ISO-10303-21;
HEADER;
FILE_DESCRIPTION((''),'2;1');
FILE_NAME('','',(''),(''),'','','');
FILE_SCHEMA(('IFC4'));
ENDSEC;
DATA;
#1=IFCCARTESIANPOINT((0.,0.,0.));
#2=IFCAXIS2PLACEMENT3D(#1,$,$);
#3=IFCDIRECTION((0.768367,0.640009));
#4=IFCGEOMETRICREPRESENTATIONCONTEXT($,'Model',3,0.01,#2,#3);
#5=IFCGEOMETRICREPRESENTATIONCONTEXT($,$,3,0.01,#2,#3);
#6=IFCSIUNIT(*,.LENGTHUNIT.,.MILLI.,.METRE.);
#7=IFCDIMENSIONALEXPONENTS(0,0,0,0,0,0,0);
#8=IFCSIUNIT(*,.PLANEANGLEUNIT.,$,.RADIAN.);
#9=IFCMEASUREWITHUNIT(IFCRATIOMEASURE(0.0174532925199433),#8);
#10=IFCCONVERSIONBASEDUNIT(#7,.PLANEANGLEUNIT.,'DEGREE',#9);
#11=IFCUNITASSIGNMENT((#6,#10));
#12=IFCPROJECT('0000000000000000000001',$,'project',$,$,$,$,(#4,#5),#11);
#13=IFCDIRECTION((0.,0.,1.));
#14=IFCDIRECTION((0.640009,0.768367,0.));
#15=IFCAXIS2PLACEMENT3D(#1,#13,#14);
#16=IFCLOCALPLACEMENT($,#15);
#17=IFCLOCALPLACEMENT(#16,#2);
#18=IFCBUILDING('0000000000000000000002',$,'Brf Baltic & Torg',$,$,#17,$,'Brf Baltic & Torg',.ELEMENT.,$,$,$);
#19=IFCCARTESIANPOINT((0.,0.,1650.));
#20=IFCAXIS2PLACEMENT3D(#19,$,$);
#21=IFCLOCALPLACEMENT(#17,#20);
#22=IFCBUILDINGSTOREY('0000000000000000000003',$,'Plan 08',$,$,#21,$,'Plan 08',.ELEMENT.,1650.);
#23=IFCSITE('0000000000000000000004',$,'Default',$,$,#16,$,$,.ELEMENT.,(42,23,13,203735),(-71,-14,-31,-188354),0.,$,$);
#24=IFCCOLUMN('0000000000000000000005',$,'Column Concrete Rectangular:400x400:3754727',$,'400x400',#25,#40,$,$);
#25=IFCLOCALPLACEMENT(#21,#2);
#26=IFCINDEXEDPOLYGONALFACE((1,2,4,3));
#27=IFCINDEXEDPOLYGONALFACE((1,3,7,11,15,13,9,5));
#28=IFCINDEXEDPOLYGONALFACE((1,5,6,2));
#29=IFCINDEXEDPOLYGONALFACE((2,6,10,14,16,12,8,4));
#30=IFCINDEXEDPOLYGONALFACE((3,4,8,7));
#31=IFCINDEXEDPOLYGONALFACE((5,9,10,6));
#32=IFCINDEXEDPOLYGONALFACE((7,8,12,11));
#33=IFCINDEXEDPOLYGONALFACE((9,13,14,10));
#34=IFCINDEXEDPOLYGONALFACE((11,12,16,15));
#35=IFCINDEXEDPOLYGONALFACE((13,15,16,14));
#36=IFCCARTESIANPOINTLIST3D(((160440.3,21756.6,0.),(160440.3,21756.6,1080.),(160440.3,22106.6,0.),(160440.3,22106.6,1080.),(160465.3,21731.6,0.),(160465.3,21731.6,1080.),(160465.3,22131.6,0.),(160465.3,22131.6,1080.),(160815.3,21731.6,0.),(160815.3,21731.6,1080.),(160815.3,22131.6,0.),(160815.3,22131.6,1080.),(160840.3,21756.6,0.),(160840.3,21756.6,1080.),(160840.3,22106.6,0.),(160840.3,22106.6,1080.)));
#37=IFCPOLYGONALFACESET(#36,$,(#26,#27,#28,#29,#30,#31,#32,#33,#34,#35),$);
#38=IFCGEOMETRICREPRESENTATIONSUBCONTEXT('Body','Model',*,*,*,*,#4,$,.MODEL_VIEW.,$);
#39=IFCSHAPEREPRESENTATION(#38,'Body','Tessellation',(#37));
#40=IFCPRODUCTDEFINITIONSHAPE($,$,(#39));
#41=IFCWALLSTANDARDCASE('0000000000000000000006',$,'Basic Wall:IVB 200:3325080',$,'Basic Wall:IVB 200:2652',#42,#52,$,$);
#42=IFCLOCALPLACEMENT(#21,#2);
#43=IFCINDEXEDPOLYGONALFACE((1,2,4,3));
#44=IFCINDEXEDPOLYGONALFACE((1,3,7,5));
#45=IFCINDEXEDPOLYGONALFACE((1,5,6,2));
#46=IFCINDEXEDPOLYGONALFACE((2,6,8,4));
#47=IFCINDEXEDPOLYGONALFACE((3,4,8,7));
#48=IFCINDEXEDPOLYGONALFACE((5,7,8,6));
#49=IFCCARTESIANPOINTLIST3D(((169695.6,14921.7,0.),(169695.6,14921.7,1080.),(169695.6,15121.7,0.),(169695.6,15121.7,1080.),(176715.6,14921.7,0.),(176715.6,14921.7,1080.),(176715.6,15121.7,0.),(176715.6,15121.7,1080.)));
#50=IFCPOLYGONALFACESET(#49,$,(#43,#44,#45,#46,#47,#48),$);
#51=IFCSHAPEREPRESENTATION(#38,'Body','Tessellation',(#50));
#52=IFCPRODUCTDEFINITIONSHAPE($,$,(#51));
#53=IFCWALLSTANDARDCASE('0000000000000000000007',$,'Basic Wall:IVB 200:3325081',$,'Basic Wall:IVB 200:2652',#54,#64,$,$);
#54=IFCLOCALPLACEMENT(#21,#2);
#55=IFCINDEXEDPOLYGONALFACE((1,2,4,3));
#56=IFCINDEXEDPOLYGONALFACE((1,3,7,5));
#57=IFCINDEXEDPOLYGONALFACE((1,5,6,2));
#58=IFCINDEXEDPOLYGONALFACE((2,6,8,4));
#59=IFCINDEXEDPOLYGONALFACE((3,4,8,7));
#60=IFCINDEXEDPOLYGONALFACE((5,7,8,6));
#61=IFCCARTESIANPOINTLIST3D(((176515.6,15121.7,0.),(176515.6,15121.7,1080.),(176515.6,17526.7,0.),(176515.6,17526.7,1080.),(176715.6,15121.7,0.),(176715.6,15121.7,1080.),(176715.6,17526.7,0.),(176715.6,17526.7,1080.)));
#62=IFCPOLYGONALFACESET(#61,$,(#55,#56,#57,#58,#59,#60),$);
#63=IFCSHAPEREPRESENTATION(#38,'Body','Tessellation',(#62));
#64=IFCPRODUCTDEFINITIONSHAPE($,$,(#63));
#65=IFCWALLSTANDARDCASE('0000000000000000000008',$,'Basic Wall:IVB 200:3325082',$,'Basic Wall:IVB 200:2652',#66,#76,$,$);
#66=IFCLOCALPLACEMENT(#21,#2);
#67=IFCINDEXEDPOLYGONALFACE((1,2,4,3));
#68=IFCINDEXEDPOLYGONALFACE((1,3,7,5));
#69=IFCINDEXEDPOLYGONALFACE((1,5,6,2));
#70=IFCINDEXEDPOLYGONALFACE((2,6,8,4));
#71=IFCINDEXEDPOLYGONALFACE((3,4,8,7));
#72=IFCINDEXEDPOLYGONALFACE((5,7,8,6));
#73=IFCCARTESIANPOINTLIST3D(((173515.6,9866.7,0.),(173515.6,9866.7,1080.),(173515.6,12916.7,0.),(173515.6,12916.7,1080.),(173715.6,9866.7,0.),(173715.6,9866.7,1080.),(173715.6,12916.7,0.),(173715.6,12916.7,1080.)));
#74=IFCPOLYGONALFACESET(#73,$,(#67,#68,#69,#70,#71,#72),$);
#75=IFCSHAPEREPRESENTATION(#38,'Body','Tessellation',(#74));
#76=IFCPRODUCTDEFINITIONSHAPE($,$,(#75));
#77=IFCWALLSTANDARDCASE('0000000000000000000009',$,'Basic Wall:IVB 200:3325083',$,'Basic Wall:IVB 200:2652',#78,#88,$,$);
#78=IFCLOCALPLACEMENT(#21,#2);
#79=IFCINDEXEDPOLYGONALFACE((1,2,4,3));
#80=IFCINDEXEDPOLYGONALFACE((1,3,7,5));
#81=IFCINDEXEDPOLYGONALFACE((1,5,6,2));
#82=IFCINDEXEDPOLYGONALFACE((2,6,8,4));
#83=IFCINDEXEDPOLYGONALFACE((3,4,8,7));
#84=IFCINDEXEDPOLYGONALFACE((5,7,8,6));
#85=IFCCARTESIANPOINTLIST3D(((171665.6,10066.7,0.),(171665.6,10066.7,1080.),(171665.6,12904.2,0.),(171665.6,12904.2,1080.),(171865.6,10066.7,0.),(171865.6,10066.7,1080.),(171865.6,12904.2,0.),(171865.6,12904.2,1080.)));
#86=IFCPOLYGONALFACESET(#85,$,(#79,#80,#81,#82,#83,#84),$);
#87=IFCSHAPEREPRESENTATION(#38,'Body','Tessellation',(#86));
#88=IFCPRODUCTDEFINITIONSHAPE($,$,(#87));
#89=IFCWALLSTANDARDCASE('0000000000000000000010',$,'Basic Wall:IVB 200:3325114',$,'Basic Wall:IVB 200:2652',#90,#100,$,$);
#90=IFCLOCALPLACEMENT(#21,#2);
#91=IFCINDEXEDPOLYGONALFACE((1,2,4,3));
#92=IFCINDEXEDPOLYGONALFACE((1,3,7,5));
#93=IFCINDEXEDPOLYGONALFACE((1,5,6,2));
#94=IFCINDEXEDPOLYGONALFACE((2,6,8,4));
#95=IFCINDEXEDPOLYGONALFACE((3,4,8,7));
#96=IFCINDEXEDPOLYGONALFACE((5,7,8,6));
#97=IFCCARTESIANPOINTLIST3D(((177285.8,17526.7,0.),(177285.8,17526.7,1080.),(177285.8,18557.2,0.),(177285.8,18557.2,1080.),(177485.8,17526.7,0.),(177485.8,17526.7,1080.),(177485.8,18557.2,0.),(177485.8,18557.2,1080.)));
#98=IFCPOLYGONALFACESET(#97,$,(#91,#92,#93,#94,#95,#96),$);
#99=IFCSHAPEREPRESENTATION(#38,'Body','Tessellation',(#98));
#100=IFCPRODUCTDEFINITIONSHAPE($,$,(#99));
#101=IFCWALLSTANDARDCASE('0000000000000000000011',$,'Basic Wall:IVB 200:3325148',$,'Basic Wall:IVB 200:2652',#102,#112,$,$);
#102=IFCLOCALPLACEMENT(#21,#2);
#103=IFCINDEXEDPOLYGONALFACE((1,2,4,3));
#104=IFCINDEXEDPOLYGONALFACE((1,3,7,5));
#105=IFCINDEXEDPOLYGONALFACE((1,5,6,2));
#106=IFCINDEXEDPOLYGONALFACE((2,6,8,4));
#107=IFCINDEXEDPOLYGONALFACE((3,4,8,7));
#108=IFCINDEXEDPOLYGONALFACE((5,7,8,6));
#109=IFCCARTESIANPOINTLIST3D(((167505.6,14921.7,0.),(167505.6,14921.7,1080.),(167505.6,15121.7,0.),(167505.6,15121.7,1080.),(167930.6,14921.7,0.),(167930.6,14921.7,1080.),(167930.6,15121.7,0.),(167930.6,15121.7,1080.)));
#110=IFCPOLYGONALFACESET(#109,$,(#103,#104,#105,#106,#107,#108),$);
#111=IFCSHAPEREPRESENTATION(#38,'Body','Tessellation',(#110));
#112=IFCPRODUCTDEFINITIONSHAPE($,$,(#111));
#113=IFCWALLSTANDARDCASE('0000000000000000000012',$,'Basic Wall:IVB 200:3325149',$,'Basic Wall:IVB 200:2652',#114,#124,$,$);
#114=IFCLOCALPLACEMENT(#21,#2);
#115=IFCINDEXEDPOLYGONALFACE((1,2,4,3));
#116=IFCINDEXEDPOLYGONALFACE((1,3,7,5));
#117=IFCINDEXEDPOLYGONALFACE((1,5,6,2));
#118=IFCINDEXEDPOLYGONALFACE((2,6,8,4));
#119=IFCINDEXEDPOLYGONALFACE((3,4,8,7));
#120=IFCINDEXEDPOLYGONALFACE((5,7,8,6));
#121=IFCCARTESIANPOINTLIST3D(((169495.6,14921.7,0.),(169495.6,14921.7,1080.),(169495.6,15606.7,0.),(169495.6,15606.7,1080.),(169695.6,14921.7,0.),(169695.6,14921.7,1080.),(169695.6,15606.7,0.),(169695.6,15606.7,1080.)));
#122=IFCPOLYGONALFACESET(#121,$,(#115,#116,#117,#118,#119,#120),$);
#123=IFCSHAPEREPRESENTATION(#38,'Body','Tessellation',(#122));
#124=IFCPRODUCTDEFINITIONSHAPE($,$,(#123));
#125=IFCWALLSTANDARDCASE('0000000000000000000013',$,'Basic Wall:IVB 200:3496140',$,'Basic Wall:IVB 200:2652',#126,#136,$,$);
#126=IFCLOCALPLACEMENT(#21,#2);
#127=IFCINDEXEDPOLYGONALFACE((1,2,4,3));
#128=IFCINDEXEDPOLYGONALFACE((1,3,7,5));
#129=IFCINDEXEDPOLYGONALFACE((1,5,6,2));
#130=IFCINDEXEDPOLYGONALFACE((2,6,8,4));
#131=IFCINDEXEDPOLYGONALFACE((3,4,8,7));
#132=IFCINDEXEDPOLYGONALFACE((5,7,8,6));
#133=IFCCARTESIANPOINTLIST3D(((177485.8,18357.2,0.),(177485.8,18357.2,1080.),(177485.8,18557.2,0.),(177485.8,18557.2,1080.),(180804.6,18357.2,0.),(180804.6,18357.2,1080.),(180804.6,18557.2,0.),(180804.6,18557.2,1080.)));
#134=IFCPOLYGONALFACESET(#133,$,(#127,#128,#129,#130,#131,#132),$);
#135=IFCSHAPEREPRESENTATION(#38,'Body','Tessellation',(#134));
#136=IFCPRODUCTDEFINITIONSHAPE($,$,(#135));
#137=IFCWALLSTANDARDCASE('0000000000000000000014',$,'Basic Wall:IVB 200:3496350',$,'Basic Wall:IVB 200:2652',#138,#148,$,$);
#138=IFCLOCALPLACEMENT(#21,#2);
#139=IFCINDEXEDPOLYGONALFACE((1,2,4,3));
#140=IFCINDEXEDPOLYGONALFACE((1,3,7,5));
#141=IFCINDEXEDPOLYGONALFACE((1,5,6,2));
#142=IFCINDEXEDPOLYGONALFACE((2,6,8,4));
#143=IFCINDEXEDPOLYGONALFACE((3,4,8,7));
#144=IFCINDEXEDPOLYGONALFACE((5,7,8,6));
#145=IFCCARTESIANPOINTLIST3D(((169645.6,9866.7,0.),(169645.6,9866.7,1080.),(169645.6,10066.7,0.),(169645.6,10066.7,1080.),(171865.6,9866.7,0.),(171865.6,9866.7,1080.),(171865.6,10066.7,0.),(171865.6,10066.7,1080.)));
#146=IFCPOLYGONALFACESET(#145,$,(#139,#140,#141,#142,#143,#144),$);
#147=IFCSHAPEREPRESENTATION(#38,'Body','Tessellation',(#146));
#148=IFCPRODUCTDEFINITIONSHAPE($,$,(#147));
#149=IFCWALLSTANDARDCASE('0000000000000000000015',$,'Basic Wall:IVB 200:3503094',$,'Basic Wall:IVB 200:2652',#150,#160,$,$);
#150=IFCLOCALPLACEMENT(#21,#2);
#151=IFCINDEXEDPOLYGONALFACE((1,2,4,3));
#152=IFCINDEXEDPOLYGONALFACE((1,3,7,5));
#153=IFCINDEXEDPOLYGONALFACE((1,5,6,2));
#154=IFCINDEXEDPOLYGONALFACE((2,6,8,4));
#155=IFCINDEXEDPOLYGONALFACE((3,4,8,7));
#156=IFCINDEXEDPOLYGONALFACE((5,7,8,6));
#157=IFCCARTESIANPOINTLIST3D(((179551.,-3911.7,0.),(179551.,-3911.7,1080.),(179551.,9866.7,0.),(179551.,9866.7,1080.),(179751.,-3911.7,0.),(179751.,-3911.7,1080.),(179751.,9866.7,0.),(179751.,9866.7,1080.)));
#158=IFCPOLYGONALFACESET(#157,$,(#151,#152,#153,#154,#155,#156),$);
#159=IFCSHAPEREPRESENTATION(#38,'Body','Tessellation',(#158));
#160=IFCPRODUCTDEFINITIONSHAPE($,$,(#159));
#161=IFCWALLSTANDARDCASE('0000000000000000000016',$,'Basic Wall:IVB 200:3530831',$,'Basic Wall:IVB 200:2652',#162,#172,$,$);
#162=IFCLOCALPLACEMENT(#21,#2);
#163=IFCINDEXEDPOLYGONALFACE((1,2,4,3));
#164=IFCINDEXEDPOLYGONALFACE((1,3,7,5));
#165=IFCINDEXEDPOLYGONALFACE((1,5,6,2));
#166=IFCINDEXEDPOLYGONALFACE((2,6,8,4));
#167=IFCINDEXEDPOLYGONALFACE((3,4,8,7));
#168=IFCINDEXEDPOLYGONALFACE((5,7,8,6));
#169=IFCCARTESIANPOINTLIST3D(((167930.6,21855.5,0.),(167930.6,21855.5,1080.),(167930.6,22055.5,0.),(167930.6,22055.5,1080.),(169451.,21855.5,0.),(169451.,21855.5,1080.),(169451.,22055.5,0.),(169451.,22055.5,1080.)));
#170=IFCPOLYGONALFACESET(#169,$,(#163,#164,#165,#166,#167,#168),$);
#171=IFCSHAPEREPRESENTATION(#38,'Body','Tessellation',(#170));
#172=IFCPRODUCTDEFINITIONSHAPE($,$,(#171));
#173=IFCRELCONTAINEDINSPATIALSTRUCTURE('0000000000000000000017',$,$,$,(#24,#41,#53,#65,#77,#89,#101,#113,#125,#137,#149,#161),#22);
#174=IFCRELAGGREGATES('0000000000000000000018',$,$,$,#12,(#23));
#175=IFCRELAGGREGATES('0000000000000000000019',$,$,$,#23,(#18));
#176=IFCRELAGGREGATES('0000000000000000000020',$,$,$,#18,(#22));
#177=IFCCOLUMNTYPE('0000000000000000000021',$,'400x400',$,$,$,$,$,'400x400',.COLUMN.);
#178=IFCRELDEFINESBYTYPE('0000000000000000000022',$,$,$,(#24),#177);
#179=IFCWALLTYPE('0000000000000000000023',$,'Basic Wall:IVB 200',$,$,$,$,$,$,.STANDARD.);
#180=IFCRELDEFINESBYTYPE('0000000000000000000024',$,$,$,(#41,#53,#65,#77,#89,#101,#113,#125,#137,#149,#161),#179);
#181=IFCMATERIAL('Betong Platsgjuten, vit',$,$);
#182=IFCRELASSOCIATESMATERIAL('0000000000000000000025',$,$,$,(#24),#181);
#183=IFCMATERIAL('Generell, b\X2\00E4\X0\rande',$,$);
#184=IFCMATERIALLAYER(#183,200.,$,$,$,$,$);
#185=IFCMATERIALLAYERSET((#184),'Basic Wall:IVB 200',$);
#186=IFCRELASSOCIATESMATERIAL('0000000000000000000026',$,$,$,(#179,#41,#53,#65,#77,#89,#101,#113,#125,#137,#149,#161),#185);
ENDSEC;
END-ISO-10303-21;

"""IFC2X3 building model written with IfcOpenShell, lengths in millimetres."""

from ifc_helpers import new_model, entity, si_unit, converted_unit, direction, frame, frame_2d, origin, place, context, subcontext, project, spatial, polyline, rectangle, outline, extrude, clip, halfspace, source, transform, mapped, material, layer, layer_set, layer_usage, type_object, type_shapes, element, save


model = new_model("IFC2X3")

# Units and contexts
model_context = context("Model", 3, precision=0.01, world=origin(), true_north=direction((0.768367, 0.640009)))
context_of_model = context(None, 3, precision=0.01, world=origin(), true_north=direction((0.768367, 0.640009)))
body_context = subcontext(model_context, "Body", "Model", "MODEL_VIEW")
ifc_project = project(units=[si_unit("LENGTHUNIT", "METRE", prefix="MILLI"), converted_unit("PLANEANGLEUNIT", "DEGREE", entity("IfcRatioMeasure", 0.0174532925199433), si_unit("PLANEANGLEUNIT", "RADIAN"), dimensions=[0, 0, 0, 0, 0, 0, 0])], contexts=[model_context, context_of_model])

# Site, building, storey
site_placement = place(None, frame((0.0, 0.0, 0.0), z_axis=(0.0, 0.0, 1.0), x_axis=(0.640009, 0.768367, 0.0)))
site = spatial("IfcSite", under=ifc_project, at=site_placement, Name="Default", CompositionType="ELEMENT", RefLatitude=(42, 23, 13, 203735), RefLongitude=(-71, -14, -31, -188354), RefElevation=0.0)
building_placement = place(site_placement, origin())
building = spatial("IfcBuilding", under=site, at=building_placement, Name="Brf Baltic & Torg", LongName="Brf Baltic & Torg", CompositionType="ELEMENT")
storey_placement = place(building_placement, frame((0.0, 0.0, 1650.0)))
storey = spatial("IfcBuildingStorey", under=building, at=storey_placement, Name="Plan 08", LongName="Plan 08", CompositionType="ELEMENT", Elevation=1650.0)

# Column
ifc_material_1 = material(Name="Betong Platsgjuten, vit")
column_type = type_object("IfcColumnType", Name="400x400", ElementType="400x400", PredefinedType="COLUMN")
shared_shape = source(origin(), body_context, "Body", "SweptSolid", [
    extrude(outline(polyline([(-175.0, -200.0), (175.0, -200.0), (200.0, -175.0), (200.0, 175.0), (175.0, 200.0), (-175.0, 200.0), (-200.0, 175.0), (-200.0, -175.0), (-175.0, -200.0)])), frame((0.0, 0.0, 1650.0), z_axis=(0.0, 0.0, 1.0), x_axis=(0.0, -1.0, 0.0)), (0.0, 0.0, 1.0), 1080.0),
])
type_shapes(column_type, [shared_shape])
column_placement = place(storey_placement, frame((160640.3, 21931.6, -1650.0)))
element("IfcColumn", 1, at=column_placement, inside=storey, type_object=column_type, material=ifc_material_1, Name="Column Concrete Rectangular:400x400:3754727", ObjectType="400x400", context=body_context, shape_type="MappedRepresentation", body=[
    mapped(shared_shape, transform((0.0, 0.0, 0.0), scale=1.0)),
])

# Walls
ifc_material_2 = material(Name="Generell, bärande")
ifc_layer = layer(ifc_material_2, 200.0)
ifc_layer_set = layer_set([ifc_layer], Name="Basic Wall:IVB 200")
ifc_layer_usage_1 = layer_usage(ifc_layer_set, "AXIS2", "NEGATIVE", 100.0)
wall_type = type_object("IfcWallType", Name="Basic Wall:IVB 200", PredefinedType="STANDARD", material=ifc_layer_set)
wall_1_placement = place(storey_placement, frame((169695.6, 15021.7, 0.0)))
element("IfcWallStandardCase", 2, at=wall_1_placement, inside=storey, type_object=wall_type, material=ifc_layer_usage_1, Name="Basic Wall:IVB 200:3325080", ObjectType="Basic Wall:IVB 200:2652", context=body_context, shape_type="Clipping", body=[
    clip(extrude(rectangle(XDim=7020.0, YDim=200.0, at=frame_2d((3510.0, 0.0), x_axis=(-1.0, 0.0))), origin(), (0.0, 0.0, 1.0), 1080.0), halfspace(origin(), True)),
])
ifc_layer_usage_2 = layer_usage(ifc_layer_set, "AXIS2", "NEGATIVE", 100.0)
wall_2_placement = place(storey_placement, frame((176615.6, 15121.7, 0.0), z_axis=(0.0, 0.0, 1.0), x_axis=(0.0, 1.0, 0.0)))
element("IfcWallStandardCase", 3, at=wall_2_placement, inside=storey, type_object=wall_type, material=ifc_layer_usage_2, Name="Basic Wall:IVB 200:3325081", ObjectType="Basic Wall:IVB 200:2652", context=body_context, shape_type="Clipping", body=[
    clip(extrude(rectangle(XDim=2405.0, YDim=200.0, at=frame_2d((1202.5, 0.0), x_axis=(-1.0, 0.0))), origin(), (0.0, 0.0, 1.0), 1080.0), halfspace(origin(), True)),
])
ifc_layer_usage_3 = layer_usage(ifc_layer_set, "AXIS2", "NEGATIVE", 100.0)
wall_3_placement = place(storey_placement, frame((173615.6, 9866.7, 0.0), z_axis=(0.0, 0.0, 1.0), x_axis=(0.0, 1.0, 0.0)))
element("IfcWallStandardCase", 4, at=wall_3_placement, inside=storey, type_object=wall_type, material=ifc_layer_usage_3, Name="Basic Wall:IVB 200:3325082", ObjectType="Basic Wall:IVB 200:2652", context=body_context, shape_type="Clipping", body=[
    clip(extrude(rectangle(XDim=3050.0, YDim=200.0, at=frame_2d((1525.0, 0.0), x_axis=(-1.0, 0.0))), origin(), (0.0, 0.0, 1.0), 1080.0), halfspace(origin(), True)),
])
ifc_layer_usage_4 = layer_usage(ifc_layer_set, "AXIS2", "NEGATIVE", 100.0)
wall_4_placement = place(storey_placement, frame((171765.6, 10066.7, 0.0), z_axis=(0.0, 0.0, 1.0), x_axis=(0.0, 1.0, 0.0)))
element("IfcWallStandardCase", 5, at=wall_4_placement, inside=storey, type_object=wall_type, material=ifc_layer_usage_4, Name="Basic Wall:IVB 200:3325083", ObjectType="Basic Wall:IVB 200:2652", context=body_context, shape_type="Clipping", body=[
    clip(extrude(rectangle(XDim=2837.5, YDim=200.0, at=frame_2d((1418.8, 0.0), x_axis=(-1.0, 0.0))), origin(), (0.0, 0.0, 1.0), 1080.0), halfspace(origin(), True)),
])

# Wall
ifc_layer_usage_5 = layer_usage(ifc_layer_set, "AXIS2", "NEGATIVE", 100.0)
wall_5_placement = place(storey_placement, frame((177385.8, 17526.7, 0.0), z_axis=(0.0, 0.0, 1.0), x_axis=(0.0, 1.0, 0.0)))
element("IfcWallStandardCase", 6, at=wall_5_placement, inside=storey, type_object=wall_type, material=ifc_layer_usage_5, Name="Basic Wall:IVB 200:3325114", ObjectType="Basic Wall:IVB 200:2652", context=body_context, shape_type="Clipping", body=[
    clip(extrude(rectangle(XDim=1030.5, YDim=200.0, at=frame_2d((515.2, 0.0), x_axis=(-1.0, 0.0))), origin(), (0.0, 0.0, 1.0), 1080.0), halfspace(origin(), True)),
])

# Walls
ifc_layer_usage_6 = layer_usage(ifc_layer_set, "AXIS2", "POSITIVE", -100.0)
wall_6_placement = place(storey_placement, frame((167930.6, 15021.7, 0.0), z_axis=(0.0, 0.0, 1.0), x_axis=(-1.0, 0.0, 0.0)))
element("IfcWallStandardCase", 7, at=wall_6_placement, inside=storey, type_object=wall_type, material=ifc_layer_usage_6, Name="Basic Wall:IVB 200:3325148", ObjectType="Basic Wall:IVB 200:2652", context=body_context, shape_type="Clipping", body=[
    clip(extrude(rectangle(XDim=425.0, YDim=200.0, at=frame_2d((212.5, 0.0), x_axis=(-1.0, 0.0))), origin(), (0.0, 0.0, 1.0), 1080.0), halfspace(origin(), True)),
])
ifc_layer_usage_7 = layer_usage(ifc_layer_set, "AXIS2", "POSITIVE", -100.0)
wall_7_placement = place(storey_placement, frame((169595.6, 15606.7, 0.0), z_axis=(0.0, 0.0, 1.0), x_axis=(0.0, -1.0, 0.0)))
element("IfcWallStandardCase", 8, at=wall_7_placement, inside=storey, type_object=wall_type, material=ifc_layer_usage_7, Name="Basic Wall:IVB 200:3325149", ObjectType="Basic Wall:IVB 200:2652", context=body_context, shape_type="Clipping", body=[
    clip(extrude(rectangle(XDim=685.0, YDim=200.0, at=frame_2d((342.5, 0.0), x_axis=(-1.0, 0.0))), origin(), (0.0, 0.0, 1.0), 1080.0), halfspace(origin(), True)),
])
ifc_layer_usage_8 = layer_usage(ifc_layer_set, "AXIS2", "NEGATIVE", 100.0)
wall_8_placement = place(storey_placement, frame((177485.8, 18457.2, 0.0)))
element("IfcWallStandardCase", 9, at=wall_8_placement, inside=storey, type_object=wall_type, material=ifc_layer_usage_8, Name="Basic Wall:IVB 200:3496140", ObjectType="Basic Wall:IVB 200:2652", context=body_context, shape_type="Clipping", body=[
    clip(extrude(rectangle(XDim=3318.8, YDim=200.0, at=frame_2d((1659.4, 0.0), x_axis=(-1.0, 0.0))), origin(), (0.0, 0.0, 1.0), 1080.0), halfspace(origin(), True)),
])
ifc_layer_usage_9 = layer_usage(ifc_layer_set, "AXIS2", "POSITIVE", -100.0)
wall_9_placement = place(storey_placement, frame((169645.6, 9966.7, 0.0)))
element("IfcWallStandardCase", 10, at=wall_9_placement, inside=storey, type_object=wall_type, material=ifc_layer_usage_9, Name="Basic Wall:IVB 200:3496350", ObjectType="Basic Wall:IVB 200:2652", context=body_context, shape_type="Clipping", body=[
    clip(extrude(rectangle(XDim=2220.0, YDim=200.0, at=frame_2d((1110.0, 0.0), x_axis=(-1.0, 0.0))), origin(), (0.0, 0.0, 1.0), 1080.0), halfspace(origin(), True)),
])
ifc_layer_usage_10 = layer_usage(ifc_layer_set, "AXIS2", "NEGATIVE", 100.0)
wall_10_placement = place(storey_placement, frame((179651.0, 9866.7, 0.0), z_axis=(0.0, 0.0, 1.0), x_axis=(0.0, -1.0, 0.0)))
element("IfcWallStandardCase", 11, at=wall_10_placement, inside=storey, type_object=wall_type, material=ifc_layer_usage_10, Name="Basic Wall:IVB 200:3503094", ObjectType="Basic Wall:IVB 200:2652", context=body_context, shape_type="Clipping", body=[
    clip(extrude(rectangle(XDim=13778.4, YDim=200.0, at=frame_2d((6889.2, 0.0), x_axis=(-1.0, 0.0))), origin(), (0.0, 0.0, 1.0), 1080.0), halfspace(origin(), True)),
])

# Wall
ifc_layer_usage_11 = layer_usage(ifc_layer_set, "AXIS2", "NEGATIVE", 100.0)
wall_11_placement = place(storey_placement, frame((167930.6, 21955.5, 0.0)))
element("IfcWallStandardCase", 12, at=wall_11_placement, inside=storey, type_object=wall_type, material=ifc_layer_usage_11, Name="Basic Wall:IVB 200:3530831", ObjectType="Basic Wall:IVB 200:2652", context=body_context, shape_type="Clipping", body=[
    clip(extrude(rectangle(XDim=1520.4, YDim=200.0, at=frame_2d((760.2, 0.0), x_axis=(-1.0, 0.0))), origin(), (0.0, 0.0, 1.0), 1080.0), halfspace(origin(), True)),
])

save(model, "model.ifc")
